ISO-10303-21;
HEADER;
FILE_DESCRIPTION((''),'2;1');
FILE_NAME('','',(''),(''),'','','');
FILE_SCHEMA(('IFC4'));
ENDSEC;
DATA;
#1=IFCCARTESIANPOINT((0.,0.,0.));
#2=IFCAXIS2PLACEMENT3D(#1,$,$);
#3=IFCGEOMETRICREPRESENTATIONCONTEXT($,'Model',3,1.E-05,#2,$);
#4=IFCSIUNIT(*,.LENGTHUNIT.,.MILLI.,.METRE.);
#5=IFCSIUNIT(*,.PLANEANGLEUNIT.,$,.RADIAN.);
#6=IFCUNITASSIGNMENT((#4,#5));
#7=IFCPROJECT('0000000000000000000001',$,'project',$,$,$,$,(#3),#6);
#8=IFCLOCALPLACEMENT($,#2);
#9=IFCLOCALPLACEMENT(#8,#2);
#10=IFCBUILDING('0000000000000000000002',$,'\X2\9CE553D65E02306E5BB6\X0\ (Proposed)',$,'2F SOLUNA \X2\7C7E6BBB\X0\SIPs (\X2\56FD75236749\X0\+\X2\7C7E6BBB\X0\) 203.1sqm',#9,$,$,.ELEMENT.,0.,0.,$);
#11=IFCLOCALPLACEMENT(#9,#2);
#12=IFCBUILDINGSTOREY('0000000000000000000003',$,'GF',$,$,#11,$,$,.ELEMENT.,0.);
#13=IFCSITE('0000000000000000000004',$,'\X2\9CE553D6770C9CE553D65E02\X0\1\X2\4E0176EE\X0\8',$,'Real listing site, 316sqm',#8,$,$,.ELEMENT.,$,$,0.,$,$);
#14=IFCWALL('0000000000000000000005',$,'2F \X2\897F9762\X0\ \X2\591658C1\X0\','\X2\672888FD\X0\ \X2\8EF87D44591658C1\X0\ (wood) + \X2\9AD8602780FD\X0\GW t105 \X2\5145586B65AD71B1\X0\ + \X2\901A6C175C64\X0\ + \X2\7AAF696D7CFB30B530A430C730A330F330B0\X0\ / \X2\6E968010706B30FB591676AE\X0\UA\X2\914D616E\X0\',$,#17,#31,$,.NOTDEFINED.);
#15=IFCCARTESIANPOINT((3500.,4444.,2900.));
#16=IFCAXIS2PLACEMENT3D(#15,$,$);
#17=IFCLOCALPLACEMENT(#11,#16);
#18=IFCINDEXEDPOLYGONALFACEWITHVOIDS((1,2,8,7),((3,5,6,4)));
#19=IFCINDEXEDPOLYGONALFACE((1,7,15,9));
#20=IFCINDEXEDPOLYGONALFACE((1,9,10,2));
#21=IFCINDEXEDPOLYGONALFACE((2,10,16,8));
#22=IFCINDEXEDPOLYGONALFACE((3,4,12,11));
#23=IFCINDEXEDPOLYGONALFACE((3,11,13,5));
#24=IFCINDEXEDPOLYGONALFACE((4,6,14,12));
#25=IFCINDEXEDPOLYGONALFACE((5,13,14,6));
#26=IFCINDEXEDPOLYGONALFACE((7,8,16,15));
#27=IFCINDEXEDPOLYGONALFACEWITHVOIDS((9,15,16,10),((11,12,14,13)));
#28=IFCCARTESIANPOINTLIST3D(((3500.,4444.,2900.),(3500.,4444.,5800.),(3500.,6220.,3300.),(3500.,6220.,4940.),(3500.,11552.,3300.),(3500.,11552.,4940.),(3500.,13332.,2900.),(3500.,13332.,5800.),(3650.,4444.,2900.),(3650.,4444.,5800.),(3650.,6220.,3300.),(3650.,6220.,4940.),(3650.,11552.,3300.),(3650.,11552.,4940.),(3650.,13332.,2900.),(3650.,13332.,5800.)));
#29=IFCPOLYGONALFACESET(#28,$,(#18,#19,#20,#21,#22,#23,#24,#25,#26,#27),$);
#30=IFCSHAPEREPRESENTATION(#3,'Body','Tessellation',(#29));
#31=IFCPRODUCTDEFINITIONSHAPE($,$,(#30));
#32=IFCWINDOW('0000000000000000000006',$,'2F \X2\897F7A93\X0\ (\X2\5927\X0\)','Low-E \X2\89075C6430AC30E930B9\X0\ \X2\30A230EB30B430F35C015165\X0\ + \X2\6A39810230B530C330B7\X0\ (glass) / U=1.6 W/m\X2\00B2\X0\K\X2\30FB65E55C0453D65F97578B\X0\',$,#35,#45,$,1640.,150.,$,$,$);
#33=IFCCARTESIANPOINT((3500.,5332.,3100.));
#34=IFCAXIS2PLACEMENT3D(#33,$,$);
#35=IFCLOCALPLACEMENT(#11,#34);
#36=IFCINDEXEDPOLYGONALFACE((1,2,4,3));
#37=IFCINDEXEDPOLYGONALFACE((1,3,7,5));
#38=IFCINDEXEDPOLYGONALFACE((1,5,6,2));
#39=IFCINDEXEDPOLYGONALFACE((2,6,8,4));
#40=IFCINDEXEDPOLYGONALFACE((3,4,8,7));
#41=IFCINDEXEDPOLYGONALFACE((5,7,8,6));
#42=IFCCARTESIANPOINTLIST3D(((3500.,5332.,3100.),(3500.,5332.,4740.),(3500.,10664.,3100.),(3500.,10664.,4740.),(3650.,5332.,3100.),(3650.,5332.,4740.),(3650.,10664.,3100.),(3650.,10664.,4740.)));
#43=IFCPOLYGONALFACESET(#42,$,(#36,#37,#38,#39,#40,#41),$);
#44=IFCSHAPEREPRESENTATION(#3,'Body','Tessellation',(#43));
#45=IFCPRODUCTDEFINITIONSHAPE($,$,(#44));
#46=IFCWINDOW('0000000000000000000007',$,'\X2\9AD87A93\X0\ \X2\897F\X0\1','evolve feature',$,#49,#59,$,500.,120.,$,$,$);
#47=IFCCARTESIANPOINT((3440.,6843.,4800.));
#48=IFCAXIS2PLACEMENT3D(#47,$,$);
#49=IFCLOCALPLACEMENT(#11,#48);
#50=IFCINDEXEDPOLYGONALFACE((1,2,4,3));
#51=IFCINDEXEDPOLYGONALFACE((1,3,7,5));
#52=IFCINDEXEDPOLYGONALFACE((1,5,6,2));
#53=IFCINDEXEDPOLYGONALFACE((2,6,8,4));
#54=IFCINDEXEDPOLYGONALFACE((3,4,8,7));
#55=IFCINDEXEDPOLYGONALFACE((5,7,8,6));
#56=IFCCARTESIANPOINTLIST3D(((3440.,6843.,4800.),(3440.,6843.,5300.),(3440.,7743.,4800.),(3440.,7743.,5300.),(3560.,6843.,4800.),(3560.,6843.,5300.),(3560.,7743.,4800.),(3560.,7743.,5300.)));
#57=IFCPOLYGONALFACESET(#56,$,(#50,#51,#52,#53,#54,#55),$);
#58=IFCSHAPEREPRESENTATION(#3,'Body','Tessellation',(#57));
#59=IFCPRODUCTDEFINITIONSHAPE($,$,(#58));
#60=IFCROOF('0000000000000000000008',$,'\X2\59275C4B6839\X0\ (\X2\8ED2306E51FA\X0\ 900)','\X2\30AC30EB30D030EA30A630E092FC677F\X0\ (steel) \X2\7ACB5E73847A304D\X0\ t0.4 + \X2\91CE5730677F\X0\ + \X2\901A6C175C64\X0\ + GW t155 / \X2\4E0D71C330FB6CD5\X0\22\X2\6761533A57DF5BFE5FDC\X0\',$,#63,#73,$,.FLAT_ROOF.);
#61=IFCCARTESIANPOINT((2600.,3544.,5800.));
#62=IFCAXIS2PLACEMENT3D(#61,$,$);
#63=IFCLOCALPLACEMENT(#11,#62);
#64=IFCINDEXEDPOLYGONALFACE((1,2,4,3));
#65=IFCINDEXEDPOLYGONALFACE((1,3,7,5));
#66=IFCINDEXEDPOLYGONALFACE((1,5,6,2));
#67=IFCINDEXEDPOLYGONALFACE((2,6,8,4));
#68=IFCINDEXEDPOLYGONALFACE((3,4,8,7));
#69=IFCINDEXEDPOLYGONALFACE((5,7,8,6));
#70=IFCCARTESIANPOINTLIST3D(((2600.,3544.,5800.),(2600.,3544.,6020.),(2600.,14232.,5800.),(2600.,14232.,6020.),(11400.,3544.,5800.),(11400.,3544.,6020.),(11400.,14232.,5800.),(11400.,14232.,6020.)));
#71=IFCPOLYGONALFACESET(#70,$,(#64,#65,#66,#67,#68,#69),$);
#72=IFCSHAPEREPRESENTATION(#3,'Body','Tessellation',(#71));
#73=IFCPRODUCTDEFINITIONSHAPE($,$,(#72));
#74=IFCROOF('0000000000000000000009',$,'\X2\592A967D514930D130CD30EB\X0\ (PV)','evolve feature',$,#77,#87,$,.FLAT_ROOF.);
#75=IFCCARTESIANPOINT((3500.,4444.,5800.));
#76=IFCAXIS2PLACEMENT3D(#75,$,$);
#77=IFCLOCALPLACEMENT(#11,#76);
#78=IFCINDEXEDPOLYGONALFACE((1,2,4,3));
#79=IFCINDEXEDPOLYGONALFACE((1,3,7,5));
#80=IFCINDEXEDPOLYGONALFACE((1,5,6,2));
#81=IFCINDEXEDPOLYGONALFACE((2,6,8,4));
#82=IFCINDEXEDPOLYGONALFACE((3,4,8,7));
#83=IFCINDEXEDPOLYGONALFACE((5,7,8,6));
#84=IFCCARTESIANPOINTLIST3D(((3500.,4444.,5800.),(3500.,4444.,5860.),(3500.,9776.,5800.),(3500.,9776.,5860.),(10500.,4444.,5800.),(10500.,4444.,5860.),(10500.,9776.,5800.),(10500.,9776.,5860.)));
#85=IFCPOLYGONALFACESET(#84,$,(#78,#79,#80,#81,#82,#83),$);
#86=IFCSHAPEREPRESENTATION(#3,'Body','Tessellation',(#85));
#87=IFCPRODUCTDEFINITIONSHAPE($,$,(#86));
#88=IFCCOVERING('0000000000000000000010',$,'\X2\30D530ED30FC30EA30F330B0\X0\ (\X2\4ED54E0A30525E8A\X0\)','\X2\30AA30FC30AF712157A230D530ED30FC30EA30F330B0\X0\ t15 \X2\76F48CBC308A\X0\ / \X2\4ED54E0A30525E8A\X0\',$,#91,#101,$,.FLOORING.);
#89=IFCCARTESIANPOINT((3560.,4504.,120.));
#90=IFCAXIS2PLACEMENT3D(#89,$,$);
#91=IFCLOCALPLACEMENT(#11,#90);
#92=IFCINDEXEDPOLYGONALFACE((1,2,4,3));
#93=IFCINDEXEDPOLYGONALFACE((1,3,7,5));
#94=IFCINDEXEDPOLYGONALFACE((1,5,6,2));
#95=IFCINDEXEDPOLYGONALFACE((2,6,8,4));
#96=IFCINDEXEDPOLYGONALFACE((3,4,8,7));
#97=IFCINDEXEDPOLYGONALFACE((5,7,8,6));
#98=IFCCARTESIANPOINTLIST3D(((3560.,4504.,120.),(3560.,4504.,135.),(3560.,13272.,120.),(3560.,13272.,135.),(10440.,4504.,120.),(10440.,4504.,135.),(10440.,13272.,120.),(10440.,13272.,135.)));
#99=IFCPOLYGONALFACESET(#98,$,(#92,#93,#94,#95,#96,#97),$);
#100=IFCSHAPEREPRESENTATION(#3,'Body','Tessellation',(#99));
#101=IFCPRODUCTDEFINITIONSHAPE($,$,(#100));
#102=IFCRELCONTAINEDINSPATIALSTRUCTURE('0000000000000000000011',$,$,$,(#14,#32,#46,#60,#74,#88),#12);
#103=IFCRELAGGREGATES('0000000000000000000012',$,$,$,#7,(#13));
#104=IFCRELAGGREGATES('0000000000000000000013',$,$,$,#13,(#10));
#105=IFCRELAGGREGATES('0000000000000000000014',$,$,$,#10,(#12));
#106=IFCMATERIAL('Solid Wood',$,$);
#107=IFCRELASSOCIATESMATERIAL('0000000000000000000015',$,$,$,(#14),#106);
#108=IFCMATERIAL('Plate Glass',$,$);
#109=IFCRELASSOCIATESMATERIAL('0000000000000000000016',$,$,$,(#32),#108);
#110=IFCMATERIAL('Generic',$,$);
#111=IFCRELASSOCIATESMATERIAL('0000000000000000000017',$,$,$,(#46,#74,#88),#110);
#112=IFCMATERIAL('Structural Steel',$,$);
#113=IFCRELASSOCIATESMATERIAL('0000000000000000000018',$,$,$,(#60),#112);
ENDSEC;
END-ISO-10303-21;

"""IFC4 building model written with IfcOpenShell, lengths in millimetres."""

from ifc_helpers import new_model, si_unit, frame, frame_2d, origin, place, context, project, spatial, rectangle, extrude, material, element, fill, save


model = new_model("IFC4")

# Units and contexts
model_context = context("Model", 3, precision=1e-05, world=origin())
ifc_project = project(units=[si_unit("LENGTHUNIT", "METRE", prefix="MILLI"), si_unit("PLANEANGLEUNIT", "RADIAN")], contexts=[model_context])

# Site, building, storey
site_placement = place(None, origin())
site = spatial("IfcSite", under=ifc_project, at=site_placement, Name="鳥取県鳥取市1丁目8", ObjectType="Real listing site, 316sqm", CompositionType="ELEMENT", RefElevation=0.0)
building_placement = place(site_placement, origin())
building = spatial("IfcBuilding", under=site, at=building_placement, Name="鳥取市の家 (Proposed)", ObjectType="2F SOLUNA 籾殻SIPs (国産杉+籾殻) 203.1sqm", CompositionType="ELEMENT", ElevationOfRefHeight=0.0, ElevationOfTerrain=0.0)
storey_placement = place(building_placement, origin())
storey = spatial("IfcBuildingStorey", under=building, at=storey_placement, Name="GF", CompositionType="ELEMENT", Elevation=0.0)

# Shared definitions
ifc_material_1 = material(Name="Solid Wood")

# Shared definitions
ifc_material_2 = material(Name="Plate Glass")
ifc_material_3 = material(Name="Generic")

# Wall, openings, windows
wall_1_placement = place(storey_placement, frame((3500.0, 4444.0, 2900.0)))
wall_1 = element("IfcWall", 1, at=wall_1_placement, inside=storey, material=ifc_material_1, Name="2F 西面 外壁", Description="木製 軸組外壁 (wood) + 高性能GW t105 充填断熱 + 通気層 + 窯業系サイディング / 準耐火・外皮UA配慮", PredefinedType="NOTDEFINED", context=model_context, shape_type="SweptSolid", body=[
    extrude(rectangle(XDim=150.0, YDim=8888.0, at=frame_2d((75.0, 4444.0))), frame((3500.0, 4444.0, 2900.0)), (0.0, 0.0, 1.0), 2900.0),
])
opening_1_placement = place(storey_placement, frame((3500.0, 5332.0, 3100.0)))
opening_1 = element("IfcOpeningElement", 2, at=opening_1_placement, cuts=wall_1, PredefinedType="NOTDEFINED", context=model_context, shape_type="SweptSolid", body=[
    extrude(rectangle(XDim=150.0, YDim=5332.0, at=frame_2d((75.0, 2666.0))), frame((3500.0, 5332.0, 3100.0)), (0.0, 0.0, 1.0), 1640.0),
])
opening_2_placement = place(storey_placement, frame((3440.0, 6843.0, 4800.0)))
opening_2 = element("IfcOpeningElement", 3, at=opening_2_placement, cuts=wall_1, PredefinedType="NOTDEFINED", context=model_context, shape_type="SweptSolid", body=[
    extrude(rectangle(XDim=120.0, YDim=900.0, at=frame_2d((60.0, 450.0))), frame((3440.0, 6843.0, 4800.0)), (0.0, 0.0, 1.0), 500.0),
])
window_1_placement = place(storey_placement, frame((3500.0, 5332.0, 3100.0)))
window_1 = element("IfcWindow", 4, at=window_1_placement, inside=storey, material=ifc_material_2, Name="2F 西窓 (大)", Description="Low-E 複層ガラス アルゴン封入 + 樹脂サッシ (glass) / U=1.6 W/m²K・日射取得型", OverallHeight=1640.0, OverallWidth=150.0, context=model_context, shape_type="SweptSolid", body=[
    extrude(rectangle(XDim=150.0, YDim=5332.0, at=frame_2d((75.0, 2666.0))), frame((3500.0, 5332.0, 3100.0)), (0.0, 0.0, 1.0), 1640.0),
])
fill(opening_1, window_1)
window_2_placement = place(storey_placement, frame((3440.0, 6843.0, 4800.0)))
window_2 = element("IfcWindow", 5, at=window_2_placement, inside=storey, material=ifc_material_3, Name="高窓 西1", Description="evolve feature", OverallHeight=500.0, OverallWidth=120.0, context=model_context, shape_type="SweptSolid", body=[
    extrude(rectangle(XDim=120.0, YDim=900.0, at=frame_2d((60.0, 450.0))), frame((3440.0, 6843.0, 4800.0)), (0.0, 0.0, 1.0), 500.0),
])
fill(opening_2, window_2)

# Roofs
ifc_material_4 = material(Name="Structural Steel")
roof_1_placement = place(storey_placement, frame((2600.0, 3544.0, 5800.0)))
element("IfcRoof", 6, at=roof_1_placement, inside=storey, material=ifc_material_4, Name="大屋根 (軒の出 900)", Description="ガルバリウム鋼板 (steel) 立平葺き t0.4 + 野地板 + 通気層 + GW t155 / 不燃・法22条区域対応", PredefinedType="FLAT_ROOF", context=model_context, shape_type="SweptSolid", body=[
    extrude(rectangle(XDim=8800.0, YDim=10688.0, at=frame_2d((4400.0, 5344.0))), frame((2600.0, 3544.0, 5800.0)), (0.0, 0.0, 1.0), 220.0),
])
roof_2_placement = place(storey_placement, frame((3500.0, 4444.0, 5800.0)))
element("IfcRoof", 7, at=roof_2_placement, inside=storey, material=ifc_material_3, Name="太陽光パネル (PV)", Description="evolve feature", PredefinedType="FLAT_ROOF", context=model_context, shape_type="SweptSolid", body=[
    extrude(rectangle(XDim=7000.0, YDim=5332.0, at=frame_2d((3500.0, 2666.0))), frame((3500.0, 4444.0, 5800.0)), (0.0, 0.0, 1.0), 60.0),
])

# Covering
covering_placement = place(storey_placement, frame((3560.0, 4504.0, 120.0)))
element("IfcCovering", 8, at=covering_placement, inside=storey, material=ifc_material_3, Name="フローリング (仕上げ床)", Description="オーク無垢フローリング t15 直貼り / 仕上げ床", PredefinedType="FLOORING", context=model_context, shape_type="SweptSolid", body=[
    extrude(rectangle(XDim=6880.0, YDim=8768.0, at=frame_2d((3440.0, 4384.0))), frame((3560.0, 4504.0, 120.0)), (0.0, 0.0, 1.0), 15.0),
])

save(model, "model.ifc")
